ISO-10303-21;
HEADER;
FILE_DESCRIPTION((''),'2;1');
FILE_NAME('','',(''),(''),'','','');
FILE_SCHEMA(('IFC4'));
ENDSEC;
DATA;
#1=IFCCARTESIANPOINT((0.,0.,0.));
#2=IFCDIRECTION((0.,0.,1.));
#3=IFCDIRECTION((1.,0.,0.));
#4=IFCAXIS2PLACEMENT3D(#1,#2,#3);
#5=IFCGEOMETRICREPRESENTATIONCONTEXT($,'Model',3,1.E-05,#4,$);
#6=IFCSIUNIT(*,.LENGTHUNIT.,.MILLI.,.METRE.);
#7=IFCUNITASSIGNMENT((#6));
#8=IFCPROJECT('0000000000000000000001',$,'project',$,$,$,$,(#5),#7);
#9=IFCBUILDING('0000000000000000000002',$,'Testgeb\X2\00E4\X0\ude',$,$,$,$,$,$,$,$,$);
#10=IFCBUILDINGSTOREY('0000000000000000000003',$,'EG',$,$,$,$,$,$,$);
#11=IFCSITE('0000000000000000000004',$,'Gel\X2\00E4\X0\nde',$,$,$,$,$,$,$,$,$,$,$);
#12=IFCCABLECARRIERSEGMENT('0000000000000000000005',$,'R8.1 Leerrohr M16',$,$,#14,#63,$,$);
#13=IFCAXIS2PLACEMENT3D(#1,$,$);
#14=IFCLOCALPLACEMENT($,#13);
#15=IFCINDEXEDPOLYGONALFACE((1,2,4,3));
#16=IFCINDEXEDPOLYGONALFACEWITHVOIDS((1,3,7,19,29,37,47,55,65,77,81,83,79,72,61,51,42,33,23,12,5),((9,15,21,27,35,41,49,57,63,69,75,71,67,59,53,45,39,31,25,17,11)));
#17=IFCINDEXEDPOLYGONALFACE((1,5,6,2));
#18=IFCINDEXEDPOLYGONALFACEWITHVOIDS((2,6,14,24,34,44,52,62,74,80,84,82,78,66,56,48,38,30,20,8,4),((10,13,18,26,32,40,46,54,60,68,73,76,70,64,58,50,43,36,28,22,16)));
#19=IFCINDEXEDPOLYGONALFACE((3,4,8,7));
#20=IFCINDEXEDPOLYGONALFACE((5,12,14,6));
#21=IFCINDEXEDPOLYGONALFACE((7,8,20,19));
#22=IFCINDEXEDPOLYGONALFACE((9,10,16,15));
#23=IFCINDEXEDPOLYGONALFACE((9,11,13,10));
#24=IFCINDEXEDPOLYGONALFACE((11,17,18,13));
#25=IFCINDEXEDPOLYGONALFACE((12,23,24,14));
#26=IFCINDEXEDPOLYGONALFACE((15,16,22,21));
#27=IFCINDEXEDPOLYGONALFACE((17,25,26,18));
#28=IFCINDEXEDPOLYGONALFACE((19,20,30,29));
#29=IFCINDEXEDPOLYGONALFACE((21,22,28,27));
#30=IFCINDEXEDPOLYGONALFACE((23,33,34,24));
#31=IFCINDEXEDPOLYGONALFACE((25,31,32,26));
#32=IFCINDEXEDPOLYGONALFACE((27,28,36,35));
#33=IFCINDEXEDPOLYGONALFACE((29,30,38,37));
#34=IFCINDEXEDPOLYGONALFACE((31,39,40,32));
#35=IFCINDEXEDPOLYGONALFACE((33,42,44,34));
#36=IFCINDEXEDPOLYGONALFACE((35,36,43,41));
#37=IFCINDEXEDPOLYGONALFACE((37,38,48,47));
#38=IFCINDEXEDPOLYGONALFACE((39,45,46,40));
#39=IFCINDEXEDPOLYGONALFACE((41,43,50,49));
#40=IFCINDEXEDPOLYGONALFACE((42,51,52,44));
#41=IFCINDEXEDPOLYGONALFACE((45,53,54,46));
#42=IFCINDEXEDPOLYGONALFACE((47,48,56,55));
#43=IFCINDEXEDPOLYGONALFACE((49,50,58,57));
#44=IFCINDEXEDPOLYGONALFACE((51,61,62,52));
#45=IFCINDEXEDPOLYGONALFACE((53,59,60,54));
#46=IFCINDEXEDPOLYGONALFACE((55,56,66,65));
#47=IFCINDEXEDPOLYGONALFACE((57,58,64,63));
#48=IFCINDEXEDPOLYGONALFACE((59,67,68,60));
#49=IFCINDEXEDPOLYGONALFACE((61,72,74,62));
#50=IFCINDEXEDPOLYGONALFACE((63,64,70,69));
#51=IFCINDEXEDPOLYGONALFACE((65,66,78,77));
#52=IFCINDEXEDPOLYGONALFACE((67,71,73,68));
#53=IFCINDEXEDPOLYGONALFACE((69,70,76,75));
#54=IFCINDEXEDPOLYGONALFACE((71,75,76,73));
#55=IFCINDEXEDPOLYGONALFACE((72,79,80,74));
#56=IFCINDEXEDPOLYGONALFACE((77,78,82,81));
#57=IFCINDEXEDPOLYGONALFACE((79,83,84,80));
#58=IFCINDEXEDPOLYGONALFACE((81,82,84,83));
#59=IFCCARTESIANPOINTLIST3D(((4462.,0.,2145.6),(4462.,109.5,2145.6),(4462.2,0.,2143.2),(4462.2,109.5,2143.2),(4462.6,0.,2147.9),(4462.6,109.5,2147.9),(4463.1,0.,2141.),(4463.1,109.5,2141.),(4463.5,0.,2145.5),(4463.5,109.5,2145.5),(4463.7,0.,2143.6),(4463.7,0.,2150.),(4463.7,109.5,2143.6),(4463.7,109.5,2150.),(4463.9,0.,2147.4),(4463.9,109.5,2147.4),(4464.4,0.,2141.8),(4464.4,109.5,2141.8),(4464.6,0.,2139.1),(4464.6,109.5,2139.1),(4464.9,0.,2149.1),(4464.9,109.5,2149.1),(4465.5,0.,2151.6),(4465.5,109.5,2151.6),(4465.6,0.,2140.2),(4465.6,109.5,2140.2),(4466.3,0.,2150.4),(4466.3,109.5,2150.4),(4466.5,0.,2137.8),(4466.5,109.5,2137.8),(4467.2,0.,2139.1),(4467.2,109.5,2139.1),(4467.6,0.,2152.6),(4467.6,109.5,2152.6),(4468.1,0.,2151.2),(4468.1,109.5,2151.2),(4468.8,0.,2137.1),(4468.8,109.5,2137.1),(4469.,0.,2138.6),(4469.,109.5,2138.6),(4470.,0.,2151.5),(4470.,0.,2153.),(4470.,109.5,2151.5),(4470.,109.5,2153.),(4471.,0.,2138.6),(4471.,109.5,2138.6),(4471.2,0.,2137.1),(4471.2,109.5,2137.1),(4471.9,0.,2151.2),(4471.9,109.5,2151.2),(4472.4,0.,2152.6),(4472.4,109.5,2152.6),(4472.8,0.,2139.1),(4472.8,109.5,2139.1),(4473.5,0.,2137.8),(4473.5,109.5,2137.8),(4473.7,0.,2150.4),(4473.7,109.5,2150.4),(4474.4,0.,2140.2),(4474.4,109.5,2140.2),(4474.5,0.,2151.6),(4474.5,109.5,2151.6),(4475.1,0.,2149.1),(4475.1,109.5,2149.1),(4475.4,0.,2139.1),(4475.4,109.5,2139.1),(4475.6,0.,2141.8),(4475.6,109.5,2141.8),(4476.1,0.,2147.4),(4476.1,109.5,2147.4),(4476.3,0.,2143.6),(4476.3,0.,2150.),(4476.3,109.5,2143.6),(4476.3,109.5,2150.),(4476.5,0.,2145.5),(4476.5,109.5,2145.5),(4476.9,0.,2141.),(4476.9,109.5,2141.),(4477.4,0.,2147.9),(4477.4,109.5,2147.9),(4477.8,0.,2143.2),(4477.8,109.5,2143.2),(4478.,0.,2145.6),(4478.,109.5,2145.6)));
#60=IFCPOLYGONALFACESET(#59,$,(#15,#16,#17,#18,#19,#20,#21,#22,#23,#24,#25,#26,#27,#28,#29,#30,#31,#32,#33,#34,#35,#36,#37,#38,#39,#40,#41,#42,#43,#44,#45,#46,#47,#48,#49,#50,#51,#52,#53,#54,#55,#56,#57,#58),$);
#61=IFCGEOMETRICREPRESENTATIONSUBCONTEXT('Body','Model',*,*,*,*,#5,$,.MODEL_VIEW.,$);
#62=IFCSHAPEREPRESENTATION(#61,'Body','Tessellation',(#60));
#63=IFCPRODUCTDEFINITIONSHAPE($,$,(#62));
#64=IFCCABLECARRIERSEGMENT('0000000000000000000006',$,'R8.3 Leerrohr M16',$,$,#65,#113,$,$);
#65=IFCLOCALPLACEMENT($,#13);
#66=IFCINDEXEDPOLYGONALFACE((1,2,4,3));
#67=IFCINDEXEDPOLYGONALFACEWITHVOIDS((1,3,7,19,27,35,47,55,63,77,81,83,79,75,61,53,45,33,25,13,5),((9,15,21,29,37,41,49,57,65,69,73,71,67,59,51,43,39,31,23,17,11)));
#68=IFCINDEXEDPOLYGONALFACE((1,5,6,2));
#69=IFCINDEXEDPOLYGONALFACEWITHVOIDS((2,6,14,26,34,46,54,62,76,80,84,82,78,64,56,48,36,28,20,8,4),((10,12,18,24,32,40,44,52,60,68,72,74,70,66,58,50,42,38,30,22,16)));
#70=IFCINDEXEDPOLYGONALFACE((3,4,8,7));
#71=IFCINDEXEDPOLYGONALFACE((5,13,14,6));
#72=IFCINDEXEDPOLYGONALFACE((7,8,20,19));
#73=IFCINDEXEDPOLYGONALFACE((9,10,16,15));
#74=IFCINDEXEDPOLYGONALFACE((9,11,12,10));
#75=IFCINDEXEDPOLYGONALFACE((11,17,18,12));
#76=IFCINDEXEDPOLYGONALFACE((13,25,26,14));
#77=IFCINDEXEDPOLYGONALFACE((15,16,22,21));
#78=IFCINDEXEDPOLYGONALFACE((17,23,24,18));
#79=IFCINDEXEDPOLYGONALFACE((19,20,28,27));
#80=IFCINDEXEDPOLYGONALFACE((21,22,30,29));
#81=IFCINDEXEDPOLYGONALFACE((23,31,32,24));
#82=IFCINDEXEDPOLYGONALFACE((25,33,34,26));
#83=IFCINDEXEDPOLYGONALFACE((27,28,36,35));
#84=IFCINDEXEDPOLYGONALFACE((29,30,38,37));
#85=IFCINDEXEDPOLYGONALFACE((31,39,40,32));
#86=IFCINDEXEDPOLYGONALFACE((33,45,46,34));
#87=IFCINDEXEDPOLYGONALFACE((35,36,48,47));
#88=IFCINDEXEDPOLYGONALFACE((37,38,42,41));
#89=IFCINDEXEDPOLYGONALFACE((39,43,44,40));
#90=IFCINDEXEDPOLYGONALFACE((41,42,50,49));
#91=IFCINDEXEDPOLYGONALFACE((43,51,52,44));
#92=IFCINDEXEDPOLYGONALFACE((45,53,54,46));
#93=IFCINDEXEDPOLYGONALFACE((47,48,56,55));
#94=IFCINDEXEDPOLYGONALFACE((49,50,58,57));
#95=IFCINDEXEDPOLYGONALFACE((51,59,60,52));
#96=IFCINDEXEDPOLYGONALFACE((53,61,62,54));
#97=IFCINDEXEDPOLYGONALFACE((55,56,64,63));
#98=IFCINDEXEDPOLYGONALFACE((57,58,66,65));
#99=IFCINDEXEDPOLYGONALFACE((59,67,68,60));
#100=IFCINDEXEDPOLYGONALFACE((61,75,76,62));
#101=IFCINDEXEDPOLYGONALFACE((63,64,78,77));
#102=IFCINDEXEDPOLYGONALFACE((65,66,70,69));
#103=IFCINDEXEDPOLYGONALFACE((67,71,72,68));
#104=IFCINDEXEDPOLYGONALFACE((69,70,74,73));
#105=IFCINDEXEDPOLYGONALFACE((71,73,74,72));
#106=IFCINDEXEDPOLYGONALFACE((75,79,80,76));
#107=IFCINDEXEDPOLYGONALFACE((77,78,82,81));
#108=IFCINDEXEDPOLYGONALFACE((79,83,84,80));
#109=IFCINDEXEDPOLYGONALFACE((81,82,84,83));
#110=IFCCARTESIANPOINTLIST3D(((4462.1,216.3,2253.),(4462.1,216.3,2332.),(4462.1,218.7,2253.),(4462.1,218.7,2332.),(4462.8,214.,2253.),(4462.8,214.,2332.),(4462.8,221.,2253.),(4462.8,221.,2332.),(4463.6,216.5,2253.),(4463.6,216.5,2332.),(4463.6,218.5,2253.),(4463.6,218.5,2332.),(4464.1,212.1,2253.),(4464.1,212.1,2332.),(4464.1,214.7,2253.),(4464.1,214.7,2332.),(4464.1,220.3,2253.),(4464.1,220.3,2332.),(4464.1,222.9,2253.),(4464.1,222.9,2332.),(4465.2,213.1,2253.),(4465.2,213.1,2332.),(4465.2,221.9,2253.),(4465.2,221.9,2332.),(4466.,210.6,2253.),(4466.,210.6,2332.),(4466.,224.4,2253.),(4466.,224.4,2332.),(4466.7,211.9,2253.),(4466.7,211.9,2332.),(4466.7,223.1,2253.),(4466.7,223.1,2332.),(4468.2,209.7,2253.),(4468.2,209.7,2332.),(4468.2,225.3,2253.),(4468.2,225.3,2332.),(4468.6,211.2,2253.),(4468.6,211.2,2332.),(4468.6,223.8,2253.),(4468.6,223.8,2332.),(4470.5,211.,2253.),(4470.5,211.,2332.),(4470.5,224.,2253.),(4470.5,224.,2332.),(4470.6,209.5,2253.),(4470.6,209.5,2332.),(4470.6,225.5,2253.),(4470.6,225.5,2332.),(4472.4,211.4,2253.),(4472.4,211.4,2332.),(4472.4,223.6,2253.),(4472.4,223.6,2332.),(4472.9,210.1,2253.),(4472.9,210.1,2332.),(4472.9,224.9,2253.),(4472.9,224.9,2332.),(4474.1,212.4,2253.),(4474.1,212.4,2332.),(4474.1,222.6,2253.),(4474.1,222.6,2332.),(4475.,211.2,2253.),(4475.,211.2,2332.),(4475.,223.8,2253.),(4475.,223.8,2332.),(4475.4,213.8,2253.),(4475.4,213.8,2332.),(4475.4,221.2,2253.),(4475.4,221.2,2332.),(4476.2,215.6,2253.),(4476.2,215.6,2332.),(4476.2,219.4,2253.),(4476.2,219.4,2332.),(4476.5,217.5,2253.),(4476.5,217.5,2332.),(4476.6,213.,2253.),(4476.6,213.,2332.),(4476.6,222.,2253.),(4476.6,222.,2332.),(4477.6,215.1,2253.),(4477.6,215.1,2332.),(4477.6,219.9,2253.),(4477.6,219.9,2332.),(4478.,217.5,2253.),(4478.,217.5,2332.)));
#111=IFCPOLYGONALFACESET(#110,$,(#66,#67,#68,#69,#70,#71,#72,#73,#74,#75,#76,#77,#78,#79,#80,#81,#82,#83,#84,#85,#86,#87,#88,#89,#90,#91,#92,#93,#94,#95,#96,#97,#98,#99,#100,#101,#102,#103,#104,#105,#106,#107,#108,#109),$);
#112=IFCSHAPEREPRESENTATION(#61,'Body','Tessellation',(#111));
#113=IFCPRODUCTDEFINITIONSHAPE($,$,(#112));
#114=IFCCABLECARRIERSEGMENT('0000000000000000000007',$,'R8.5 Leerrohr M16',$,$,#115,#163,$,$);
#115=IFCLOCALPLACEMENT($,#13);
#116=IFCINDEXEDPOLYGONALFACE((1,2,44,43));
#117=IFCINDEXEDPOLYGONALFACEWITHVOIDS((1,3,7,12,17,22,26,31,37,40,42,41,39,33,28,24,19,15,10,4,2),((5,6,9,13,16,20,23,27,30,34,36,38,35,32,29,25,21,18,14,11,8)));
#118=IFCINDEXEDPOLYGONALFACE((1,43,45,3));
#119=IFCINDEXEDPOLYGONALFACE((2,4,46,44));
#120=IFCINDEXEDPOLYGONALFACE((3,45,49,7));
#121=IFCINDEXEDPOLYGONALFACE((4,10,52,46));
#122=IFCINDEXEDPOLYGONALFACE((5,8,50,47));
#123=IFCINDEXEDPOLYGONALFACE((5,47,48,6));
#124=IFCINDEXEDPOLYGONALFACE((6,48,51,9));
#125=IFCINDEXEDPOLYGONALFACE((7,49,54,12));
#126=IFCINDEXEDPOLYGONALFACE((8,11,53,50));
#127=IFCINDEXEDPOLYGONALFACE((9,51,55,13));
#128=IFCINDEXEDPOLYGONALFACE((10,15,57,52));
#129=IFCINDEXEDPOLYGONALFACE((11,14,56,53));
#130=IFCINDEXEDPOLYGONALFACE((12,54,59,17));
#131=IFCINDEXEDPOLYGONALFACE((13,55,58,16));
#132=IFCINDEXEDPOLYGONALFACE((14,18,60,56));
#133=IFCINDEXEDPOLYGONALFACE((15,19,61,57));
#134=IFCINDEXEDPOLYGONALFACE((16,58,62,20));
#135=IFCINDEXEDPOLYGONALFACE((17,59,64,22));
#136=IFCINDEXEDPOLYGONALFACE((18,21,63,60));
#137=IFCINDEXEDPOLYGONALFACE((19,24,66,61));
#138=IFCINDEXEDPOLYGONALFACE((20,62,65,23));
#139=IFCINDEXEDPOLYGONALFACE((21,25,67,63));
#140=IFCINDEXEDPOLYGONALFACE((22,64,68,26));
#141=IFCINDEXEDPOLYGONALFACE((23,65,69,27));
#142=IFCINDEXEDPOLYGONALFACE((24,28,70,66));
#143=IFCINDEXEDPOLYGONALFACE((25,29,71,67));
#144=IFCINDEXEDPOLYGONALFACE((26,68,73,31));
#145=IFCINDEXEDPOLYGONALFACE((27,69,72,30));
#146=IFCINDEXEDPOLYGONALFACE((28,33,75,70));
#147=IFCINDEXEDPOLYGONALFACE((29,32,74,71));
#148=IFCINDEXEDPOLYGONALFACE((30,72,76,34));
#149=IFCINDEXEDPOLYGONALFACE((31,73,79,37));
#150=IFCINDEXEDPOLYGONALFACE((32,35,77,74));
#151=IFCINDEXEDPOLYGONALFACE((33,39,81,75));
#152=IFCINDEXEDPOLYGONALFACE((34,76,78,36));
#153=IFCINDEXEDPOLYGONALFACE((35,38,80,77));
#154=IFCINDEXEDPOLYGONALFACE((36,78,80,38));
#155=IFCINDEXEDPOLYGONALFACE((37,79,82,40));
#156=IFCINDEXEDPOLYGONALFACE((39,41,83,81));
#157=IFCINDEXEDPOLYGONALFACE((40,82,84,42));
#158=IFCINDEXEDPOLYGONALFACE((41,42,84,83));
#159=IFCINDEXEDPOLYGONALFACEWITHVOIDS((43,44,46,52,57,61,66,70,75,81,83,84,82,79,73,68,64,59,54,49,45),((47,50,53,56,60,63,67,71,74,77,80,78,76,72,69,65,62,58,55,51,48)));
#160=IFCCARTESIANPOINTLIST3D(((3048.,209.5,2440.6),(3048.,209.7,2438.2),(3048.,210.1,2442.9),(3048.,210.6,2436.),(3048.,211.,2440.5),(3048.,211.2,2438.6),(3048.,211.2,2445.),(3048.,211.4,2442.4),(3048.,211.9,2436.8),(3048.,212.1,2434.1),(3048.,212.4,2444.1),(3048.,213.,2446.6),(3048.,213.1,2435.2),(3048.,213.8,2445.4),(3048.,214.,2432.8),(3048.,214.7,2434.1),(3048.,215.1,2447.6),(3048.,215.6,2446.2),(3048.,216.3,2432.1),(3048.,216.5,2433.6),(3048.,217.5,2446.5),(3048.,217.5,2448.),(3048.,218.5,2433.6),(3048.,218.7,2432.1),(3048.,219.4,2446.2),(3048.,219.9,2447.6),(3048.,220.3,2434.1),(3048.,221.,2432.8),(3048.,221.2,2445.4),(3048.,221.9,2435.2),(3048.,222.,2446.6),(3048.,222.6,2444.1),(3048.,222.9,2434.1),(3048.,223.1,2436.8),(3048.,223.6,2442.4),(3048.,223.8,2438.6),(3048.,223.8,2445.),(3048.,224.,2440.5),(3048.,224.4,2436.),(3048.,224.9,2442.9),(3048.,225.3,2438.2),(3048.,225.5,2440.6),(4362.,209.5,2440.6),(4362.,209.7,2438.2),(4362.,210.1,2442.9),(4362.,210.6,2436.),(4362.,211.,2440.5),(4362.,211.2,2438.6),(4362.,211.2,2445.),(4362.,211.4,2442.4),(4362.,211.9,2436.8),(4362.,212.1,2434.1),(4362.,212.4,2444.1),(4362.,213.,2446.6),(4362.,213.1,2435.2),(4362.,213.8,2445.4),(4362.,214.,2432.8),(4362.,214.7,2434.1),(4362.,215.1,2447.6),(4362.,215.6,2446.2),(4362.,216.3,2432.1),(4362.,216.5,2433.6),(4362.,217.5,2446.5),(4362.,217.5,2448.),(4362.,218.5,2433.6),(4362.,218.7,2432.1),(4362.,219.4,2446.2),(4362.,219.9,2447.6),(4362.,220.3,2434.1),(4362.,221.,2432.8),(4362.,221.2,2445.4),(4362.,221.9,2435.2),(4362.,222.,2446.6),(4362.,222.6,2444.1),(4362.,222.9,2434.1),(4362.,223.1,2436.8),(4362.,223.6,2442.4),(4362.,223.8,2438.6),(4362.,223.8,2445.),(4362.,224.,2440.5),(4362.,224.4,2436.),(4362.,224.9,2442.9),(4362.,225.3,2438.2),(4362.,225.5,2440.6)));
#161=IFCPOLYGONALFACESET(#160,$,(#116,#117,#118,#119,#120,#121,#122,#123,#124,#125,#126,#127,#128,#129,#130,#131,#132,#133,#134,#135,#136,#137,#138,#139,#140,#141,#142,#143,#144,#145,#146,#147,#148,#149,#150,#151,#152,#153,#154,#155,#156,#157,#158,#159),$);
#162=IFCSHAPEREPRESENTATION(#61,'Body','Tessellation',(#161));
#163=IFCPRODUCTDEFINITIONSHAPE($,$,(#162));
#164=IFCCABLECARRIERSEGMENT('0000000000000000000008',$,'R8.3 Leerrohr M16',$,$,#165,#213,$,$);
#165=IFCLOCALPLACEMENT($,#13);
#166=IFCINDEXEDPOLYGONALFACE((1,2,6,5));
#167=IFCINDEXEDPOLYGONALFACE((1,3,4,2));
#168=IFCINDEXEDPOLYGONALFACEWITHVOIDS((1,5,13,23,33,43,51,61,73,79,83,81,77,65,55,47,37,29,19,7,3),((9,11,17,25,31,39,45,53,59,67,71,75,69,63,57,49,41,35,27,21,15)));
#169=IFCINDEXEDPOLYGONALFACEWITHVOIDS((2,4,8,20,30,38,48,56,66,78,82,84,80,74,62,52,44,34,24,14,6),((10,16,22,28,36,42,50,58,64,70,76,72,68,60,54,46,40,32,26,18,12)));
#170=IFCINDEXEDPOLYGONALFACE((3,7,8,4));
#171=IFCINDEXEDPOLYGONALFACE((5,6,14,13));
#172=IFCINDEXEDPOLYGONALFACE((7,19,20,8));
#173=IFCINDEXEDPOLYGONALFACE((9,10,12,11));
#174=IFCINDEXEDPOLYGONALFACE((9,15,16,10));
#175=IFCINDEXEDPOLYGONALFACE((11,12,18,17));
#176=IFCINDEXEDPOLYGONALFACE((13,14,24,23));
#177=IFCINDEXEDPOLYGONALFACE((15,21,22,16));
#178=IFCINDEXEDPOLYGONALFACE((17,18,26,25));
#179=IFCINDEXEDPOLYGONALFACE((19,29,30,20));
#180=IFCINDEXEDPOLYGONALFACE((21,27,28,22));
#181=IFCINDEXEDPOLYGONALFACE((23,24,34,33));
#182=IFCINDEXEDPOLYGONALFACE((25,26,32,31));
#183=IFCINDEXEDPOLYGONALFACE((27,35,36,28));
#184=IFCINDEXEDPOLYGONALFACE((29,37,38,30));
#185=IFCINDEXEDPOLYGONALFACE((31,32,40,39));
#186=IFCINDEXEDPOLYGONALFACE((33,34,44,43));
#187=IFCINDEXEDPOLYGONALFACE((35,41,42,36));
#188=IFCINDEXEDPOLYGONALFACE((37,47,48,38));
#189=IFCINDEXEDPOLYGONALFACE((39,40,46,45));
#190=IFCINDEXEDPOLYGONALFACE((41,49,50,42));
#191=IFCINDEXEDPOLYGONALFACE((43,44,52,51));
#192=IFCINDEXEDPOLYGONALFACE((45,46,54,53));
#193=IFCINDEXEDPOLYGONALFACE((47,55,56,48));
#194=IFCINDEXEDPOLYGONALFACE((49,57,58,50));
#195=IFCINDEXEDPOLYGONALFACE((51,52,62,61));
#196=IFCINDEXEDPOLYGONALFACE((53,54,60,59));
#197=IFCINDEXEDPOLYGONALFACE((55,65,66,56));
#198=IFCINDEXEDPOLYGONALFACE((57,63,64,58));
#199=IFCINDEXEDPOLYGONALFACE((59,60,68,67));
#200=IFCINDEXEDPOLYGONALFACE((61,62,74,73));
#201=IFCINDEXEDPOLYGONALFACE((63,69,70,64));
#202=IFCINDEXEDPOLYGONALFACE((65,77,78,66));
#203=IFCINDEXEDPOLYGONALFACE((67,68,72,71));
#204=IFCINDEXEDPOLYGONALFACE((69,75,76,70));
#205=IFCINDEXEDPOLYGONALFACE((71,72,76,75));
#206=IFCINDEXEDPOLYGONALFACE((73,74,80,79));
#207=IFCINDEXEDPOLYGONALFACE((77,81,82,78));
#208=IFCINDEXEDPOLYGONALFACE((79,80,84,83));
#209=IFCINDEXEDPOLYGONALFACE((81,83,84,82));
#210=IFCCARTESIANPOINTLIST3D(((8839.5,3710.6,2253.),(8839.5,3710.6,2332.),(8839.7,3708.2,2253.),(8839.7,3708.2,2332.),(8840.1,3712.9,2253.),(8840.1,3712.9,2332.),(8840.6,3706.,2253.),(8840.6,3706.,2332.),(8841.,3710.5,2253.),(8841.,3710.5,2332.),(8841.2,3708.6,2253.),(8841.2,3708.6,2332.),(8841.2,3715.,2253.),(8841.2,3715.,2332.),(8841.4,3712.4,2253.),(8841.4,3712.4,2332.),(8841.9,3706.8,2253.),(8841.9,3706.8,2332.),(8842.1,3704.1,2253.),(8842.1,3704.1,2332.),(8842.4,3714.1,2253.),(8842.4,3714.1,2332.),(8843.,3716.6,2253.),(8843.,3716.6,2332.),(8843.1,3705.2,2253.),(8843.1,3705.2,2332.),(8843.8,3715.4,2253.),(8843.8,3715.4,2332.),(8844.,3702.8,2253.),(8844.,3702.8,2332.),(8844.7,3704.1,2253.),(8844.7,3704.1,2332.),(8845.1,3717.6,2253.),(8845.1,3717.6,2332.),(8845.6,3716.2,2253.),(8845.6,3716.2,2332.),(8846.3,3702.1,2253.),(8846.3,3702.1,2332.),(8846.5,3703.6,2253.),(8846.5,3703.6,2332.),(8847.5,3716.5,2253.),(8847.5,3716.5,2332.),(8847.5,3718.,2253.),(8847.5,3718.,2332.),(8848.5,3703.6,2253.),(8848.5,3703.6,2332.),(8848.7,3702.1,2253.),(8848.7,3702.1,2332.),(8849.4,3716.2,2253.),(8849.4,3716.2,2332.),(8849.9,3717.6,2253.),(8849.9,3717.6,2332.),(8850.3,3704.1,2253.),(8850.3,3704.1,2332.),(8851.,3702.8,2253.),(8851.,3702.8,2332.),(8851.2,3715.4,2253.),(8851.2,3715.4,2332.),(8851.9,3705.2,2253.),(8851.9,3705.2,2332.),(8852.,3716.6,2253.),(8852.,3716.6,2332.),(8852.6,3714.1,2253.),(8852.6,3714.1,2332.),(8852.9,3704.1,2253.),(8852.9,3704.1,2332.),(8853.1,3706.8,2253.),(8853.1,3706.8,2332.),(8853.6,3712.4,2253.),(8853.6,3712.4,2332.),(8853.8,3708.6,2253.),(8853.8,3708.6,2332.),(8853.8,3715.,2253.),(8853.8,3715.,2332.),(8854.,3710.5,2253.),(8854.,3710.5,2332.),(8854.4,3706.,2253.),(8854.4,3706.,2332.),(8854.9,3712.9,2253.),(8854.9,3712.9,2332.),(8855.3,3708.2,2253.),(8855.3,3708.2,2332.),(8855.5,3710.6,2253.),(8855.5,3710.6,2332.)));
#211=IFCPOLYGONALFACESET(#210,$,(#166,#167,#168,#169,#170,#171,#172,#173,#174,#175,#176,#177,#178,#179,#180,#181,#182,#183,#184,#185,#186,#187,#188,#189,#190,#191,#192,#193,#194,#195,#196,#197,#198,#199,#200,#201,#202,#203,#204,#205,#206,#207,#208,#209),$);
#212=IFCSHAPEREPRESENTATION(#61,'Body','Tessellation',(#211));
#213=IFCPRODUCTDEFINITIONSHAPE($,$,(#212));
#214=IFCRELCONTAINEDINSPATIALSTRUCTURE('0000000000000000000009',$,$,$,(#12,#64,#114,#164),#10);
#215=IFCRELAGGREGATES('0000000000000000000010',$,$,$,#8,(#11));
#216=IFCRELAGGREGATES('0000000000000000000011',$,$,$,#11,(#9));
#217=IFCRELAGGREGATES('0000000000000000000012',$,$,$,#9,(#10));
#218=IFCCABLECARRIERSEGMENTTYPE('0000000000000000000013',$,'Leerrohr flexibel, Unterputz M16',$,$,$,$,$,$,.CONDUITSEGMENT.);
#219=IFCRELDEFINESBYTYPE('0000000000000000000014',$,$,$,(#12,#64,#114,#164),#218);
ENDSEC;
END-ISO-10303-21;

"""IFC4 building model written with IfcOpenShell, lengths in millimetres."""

from ifc_helpers import new_model, si_unit, frame, origin_with_axes, place, context, subcontext, project, spatial, hollow_circle, extrude, type_object, element, save


model = new_model("IFC4")

# Units and contexts
model_context = context("Model", 3, precision=1e-05, world=origin_with_axes())
body_context = subcontext(model_context, "Body", "Model", "MODEL_VIEW")
ifc_project = project(units=[si_unit("LENGTHUNIT", "METRE", prefix="MILLI")], contexts=[model_context])

# Site, building, storey
site = spatial("IfcSite", under=ifc_project, Name="Gelände")
building = spatial("IfcBuilding", under=site, Name="Testgebäude")
storey = spatial("IfcBuildingStorey", under=building, Name="EG")

# Cable carrier segments
cable_carrier_segment_type_1 = type_object("IfcCableCarrierSegmentType", Name="Leerrohr flexibel, Unterputz M16", PredefinedType="CONDUITSEGMENT")
cable_carrier_segment_1_placement = place(None, frame((4470.0, 0.0, 2145.0), z_axis=(0.0, 1.0, 0.0), x_axis=(0.0, 0.0, 1.0)))
element("IfcCableCarrierSegment", 1, at=cable_carrier_segment_1_placement, inside=storey, type_object=cable_carrier_segment_type_1, Name="R8.1 Leerrohr M16", context=body_context, shape_type="SweptSolid", body=[
    extrude(hollow_circle(Radius=8.0, WallThickness=1.5), None, (0.0, 0.0, 1.0), 109.5),
])
cable_carrier_segment_2_placement = place(None, frame((4470.0, 217.5, 2253.0), z_axis=(0.0, 0.0, 1.0), x_axis=(1.0, 0.0, 0.0)))
element("IfcCableCarrierSegment", 2, at=cable_carrier_segment_2_placement, inside=storey, type_object=cable_carrier_segment_type_1, Name="R8.3 Leerrohr M16", context=body_context, shape_type="SweptSolid", body=[
    extrude(hollow_circle(Radius=8.0, WallThickness=1.5), None, (0.0, 0.0, 1.0), 79.0),
])
cable_carrier_segment_3_placement = place(None, frame((4362.0, 217.5, 2440.0), z_axis=(-1.0, 0.0, 0.0), x_axis=(0.0, 0.0, 1.0)))
element("IfcCableCarrierSegment", 3, at=cable_carrier_segment_3_placement, inside=storey, type_object=cable_carrier_segment_type_1, Name="R8.5 Leerrohr M16", context=body_context, shape_type="SweptSolid", body=[
    extrude(hollow_circle(Radius=8.0, WallThickness=1.5), None, (0.0, 0.0, 1.0), 1314.0),
])
cable_carrier_segment_4_placement = place(None, frame((8847.5, 3710.0, 2253.0), z_axis=(0.0, 0.0, 1.0), x_axis=(0.0, 1.0, 0.0)))
element("IfcCableCarrierSegment", 4, at=cable_carrier_segment_4_placement, inside=storey, type_object=cable_carrier_segment_type_1, Name="R8.3 Leerrohr M16", context=body_context, shape_type="SweptSolid", body=[
    extrude(hollow_circle(Radius=8.0, WallThickness=1.5), None, (0.0, 0.0, 1.0), 79.0),
])

save(model, "model.ifc")
